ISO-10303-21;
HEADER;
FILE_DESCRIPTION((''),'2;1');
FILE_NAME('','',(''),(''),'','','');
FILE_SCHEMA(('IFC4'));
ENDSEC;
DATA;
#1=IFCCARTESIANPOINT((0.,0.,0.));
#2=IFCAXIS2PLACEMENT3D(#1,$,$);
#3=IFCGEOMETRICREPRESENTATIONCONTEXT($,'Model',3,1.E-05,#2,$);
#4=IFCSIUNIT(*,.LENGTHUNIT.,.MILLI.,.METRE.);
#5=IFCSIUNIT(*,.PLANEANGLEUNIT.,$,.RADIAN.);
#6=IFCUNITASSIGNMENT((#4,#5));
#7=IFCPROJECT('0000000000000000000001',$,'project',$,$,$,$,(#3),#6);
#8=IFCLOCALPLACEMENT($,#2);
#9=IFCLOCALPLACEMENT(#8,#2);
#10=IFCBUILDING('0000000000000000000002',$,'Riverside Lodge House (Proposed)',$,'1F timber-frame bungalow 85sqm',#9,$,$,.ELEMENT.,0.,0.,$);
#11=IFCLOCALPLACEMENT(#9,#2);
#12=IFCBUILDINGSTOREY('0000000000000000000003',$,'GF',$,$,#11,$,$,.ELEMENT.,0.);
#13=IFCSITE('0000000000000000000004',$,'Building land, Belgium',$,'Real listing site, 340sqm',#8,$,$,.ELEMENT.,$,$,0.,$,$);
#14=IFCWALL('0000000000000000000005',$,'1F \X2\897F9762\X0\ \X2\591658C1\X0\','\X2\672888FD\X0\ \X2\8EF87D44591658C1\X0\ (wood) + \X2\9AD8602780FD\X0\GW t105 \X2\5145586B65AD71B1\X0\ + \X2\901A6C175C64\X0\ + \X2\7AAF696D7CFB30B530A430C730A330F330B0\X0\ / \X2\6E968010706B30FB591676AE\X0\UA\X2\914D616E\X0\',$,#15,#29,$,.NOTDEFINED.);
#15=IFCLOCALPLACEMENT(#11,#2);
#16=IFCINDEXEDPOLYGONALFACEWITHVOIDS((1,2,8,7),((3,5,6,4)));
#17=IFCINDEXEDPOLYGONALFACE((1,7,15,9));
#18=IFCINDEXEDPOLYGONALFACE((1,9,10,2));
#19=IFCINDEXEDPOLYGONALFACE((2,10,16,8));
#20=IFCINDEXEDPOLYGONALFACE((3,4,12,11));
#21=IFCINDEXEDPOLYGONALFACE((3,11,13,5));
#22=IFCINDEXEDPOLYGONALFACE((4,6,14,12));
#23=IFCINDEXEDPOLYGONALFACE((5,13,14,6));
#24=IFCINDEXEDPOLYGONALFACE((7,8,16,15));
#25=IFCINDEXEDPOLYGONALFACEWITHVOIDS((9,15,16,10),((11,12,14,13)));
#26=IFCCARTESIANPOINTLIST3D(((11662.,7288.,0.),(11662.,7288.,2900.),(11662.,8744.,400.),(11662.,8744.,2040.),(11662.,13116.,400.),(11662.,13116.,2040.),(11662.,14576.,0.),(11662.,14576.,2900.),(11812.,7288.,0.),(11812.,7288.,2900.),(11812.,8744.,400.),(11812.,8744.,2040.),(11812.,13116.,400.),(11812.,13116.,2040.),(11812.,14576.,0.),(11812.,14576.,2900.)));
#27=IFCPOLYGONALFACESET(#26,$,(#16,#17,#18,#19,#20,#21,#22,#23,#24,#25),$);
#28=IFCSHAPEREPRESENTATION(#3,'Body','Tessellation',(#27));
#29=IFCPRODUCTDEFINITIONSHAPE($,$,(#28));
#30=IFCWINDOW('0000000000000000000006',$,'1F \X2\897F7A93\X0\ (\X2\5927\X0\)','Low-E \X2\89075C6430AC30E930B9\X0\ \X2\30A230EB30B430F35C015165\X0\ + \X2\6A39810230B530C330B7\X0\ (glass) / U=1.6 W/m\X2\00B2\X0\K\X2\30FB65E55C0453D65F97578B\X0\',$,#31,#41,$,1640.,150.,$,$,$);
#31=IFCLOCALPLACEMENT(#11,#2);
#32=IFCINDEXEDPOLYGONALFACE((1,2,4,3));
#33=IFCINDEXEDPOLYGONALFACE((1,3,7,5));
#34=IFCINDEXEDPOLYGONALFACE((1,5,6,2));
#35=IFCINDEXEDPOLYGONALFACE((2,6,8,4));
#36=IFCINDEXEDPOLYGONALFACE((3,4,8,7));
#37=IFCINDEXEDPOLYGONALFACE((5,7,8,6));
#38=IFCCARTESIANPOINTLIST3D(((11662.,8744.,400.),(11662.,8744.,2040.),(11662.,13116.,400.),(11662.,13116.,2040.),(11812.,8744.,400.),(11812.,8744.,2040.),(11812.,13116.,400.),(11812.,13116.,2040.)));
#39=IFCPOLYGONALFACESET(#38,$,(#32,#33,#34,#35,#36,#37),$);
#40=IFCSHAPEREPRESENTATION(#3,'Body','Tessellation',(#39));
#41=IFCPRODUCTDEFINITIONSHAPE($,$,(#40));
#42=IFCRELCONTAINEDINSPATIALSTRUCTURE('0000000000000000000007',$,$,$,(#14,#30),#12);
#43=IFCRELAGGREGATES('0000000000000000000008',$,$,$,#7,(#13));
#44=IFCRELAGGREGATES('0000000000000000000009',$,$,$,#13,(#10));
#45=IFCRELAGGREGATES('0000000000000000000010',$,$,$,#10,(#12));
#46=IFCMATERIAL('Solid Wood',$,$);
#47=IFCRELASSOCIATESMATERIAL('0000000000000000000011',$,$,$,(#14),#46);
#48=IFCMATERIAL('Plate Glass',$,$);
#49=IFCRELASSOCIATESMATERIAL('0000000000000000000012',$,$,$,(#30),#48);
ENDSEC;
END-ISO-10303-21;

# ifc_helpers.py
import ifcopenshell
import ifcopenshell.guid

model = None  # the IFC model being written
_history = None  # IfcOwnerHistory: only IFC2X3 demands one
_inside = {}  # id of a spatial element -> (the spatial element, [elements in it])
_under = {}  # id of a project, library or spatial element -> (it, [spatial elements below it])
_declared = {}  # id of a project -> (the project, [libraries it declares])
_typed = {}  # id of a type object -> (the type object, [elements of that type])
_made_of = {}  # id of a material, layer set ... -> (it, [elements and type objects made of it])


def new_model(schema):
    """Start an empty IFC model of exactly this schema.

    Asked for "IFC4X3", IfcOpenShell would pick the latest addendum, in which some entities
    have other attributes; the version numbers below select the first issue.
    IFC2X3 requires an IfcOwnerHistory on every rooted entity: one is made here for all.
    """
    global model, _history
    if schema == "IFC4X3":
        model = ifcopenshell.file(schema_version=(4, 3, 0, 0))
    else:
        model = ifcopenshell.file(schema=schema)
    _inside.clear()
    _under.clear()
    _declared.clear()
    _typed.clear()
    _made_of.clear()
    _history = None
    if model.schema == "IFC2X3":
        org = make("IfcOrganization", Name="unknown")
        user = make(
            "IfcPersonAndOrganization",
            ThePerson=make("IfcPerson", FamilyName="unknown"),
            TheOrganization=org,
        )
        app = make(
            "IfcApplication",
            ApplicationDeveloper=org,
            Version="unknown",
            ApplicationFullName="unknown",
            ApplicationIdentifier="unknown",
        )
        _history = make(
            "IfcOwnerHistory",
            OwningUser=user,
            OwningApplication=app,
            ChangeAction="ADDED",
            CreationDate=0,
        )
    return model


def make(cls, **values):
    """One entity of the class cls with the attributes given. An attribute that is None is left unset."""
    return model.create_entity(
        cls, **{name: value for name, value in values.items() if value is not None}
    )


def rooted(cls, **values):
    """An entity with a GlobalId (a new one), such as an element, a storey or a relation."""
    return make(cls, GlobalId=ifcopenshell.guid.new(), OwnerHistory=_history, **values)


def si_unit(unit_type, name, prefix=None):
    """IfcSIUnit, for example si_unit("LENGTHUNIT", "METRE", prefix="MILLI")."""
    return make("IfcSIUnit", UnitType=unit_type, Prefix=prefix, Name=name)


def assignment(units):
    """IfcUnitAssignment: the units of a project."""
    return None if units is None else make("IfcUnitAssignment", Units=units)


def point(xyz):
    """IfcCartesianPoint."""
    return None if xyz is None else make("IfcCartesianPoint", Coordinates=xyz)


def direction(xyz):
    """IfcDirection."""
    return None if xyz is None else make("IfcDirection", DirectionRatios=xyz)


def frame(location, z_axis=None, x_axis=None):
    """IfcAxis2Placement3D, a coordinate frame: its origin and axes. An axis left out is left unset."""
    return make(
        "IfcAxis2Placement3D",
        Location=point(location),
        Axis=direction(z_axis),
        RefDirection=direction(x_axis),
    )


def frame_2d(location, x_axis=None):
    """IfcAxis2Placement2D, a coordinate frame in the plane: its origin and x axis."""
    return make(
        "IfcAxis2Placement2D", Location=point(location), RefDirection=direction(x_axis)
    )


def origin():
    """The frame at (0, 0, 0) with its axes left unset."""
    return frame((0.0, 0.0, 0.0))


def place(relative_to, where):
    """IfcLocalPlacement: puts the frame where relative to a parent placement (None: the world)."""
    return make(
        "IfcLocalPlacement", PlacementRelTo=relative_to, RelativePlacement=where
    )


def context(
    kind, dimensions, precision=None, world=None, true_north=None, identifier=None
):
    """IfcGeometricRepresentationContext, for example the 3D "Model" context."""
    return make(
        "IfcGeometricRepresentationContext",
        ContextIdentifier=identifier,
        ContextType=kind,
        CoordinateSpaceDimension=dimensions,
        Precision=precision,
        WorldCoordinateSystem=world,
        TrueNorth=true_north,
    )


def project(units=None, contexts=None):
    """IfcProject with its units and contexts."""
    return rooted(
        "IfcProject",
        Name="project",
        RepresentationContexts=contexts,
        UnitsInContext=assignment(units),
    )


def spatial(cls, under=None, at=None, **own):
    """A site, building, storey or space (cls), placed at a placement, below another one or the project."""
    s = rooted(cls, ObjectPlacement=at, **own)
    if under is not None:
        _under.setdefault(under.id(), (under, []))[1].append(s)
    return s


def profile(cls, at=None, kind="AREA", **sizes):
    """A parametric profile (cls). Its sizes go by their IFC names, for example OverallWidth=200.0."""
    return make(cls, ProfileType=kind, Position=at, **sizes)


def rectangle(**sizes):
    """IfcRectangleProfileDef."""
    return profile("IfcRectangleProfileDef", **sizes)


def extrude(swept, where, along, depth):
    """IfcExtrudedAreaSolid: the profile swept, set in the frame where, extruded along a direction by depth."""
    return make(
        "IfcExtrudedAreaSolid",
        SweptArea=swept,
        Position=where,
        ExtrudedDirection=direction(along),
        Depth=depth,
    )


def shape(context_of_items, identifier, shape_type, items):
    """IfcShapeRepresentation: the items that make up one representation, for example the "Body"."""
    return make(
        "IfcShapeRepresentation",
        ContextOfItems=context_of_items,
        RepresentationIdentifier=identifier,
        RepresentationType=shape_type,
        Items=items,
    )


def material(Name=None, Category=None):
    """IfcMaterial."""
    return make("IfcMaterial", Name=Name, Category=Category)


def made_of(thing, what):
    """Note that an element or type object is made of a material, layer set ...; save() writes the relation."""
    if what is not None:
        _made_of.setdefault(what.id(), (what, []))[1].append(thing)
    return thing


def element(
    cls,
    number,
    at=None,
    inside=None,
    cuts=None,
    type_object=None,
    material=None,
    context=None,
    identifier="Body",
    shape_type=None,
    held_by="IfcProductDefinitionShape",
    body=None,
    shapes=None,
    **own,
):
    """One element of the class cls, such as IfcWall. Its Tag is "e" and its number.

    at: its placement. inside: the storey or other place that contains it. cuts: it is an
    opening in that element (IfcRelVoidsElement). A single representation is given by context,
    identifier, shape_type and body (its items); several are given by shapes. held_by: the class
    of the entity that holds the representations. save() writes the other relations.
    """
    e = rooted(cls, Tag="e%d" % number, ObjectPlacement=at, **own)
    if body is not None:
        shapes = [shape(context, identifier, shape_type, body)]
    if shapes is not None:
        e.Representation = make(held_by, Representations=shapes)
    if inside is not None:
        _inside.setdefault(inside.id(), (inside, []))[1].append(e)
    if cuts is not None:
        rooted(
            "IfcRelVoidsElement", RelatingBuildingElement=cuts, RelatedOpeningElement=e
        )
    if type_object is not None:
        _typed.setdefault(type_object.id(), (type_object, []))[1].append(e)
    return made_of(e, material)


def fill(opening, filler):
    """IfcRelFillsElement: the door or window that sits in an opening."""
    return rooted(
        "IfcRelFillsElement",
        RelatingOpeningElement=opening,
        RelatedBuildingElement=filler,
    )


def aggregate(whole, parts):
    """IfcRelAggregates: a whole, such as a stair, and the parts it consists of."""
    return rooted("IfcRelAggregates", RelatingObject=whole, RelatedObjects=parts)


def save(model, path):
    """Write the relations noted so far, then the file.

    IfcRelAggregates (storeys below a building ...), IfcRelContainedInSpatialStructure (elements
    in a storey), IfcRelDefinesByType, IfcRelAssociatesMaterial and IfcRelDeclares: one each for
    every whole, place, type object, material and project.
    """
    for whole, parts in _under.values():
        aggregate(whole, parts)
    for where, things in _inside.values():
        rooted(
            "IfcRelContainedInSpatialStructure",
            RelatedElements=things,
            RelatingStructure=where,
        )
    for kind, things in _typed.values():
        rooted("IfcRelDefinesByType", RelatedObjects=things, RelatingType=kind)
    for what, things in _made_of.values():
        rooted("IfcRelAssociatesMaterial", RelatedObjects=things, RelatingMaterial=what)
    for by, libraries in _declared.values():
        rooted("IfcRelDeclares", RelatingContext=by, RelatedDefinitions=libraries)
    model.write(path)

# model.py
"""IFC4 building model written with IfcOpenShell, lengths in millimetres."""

from ifc_helpers import new_model, si_unit, frame, frame_2d, origin, place, context, project, spatial, rectangle, extrude, material, element, fill, save


model = new_model("IFC4")

# Units and contexts
model_context = context("Model", 3, precision=1e-05, world=origin())
ifc_project = project(units=[si_unit("LENGTHUNIT", "METRE", prefix="MILLI"), si_unit("PLANEANGLEUNIT", "RADIAN")], contexts=[model_context])

# Site, building, storey
site_placement = place(None, origin())
site = spatial("IfcSite", under=ifc_project, at=site_placement, Name="Building land, Belgium", ObjectType="Real listing site, 340sqm", CompositionType="ELEMENT", RefElevation=0.0)
building_placement = place(site_placement, origin())
building = spatial("IfcBuilding", under=site, at=building_placement, Name="Riverside Lodge House (Proposed)", ObjectType="1F timber-frame bungalow 85sqm", CompositionType="ELEMENT", ElevationOfRefHeight=0.0, ElevationOfTerrain=0.0)
storey_placement = place(building_placement, origin())
storey = spatial("IfcBuildingStorey", under=building, at=storey_placement, Name="GF", CompositionType="ELEMENT", Elevation=0.0)

# Shared definitions
ifc_material_1 = material(Name="Solid Wood")

# Shared definitions
ifc_material_2 = material(Name="Plate Glass")

# Wall, opening, window
wall_1_placement = place(storey_placement, frame((5831.0, 3644.0, 0.0)))
wall_1 = element("IfcWall", 1, at=wall_1_placement, inside=storey, material=ifc_material_1, Name="1F 西面 外壁", Description="木製 軸組外壁 (wood) + 高性能GW t105 充填断熱 + 通気層 + 窯業系サイディング / 準耐火・外皮UA配慮", PredefinedType="NOTDEFINED", context=model_context, shape_type="SweptSolid", body=[
    extrude(rectangle(XDim=150.0, YDim=7288.0, at=frame_2d((75.0, 3644.0))), frame((5831.0, 3644.0, 0.0)), (0.0, 0.0, 1.0), 2900.0),
])
opening_1_placement = place(storey_placement, frame((5831.0, 4372.0, 200.0)))
opening_1 = element("IfcOpeningElement", 2, at=opening_1_placement, cuts=wall_1, PredefinedType="NOTDEFINED", context=model_context, shape_type="SweptSolid", body=[
    extrude(rectangle(XDim=150.0, YDim=4372.0, at=frame_2d((75.0, 2186.0))), frame((5831.0, 4372.0, 200.0)), (0.0, 0.0, 1.0), 1640.0),
])
window_1_placement = place(storey_placement, frame((5831.0, 4372.0, 200.0)))
window_1 = element("IfcWindow", 3, at=window_1_placement, inside=storey, material=ifc_material_2, Name="1F 西窓 (大)", Description="Low-E 複層ガラス アルゴン封入 + 樹脂サッシ (glass) / U=1.6 W/m²K・日射取得型", OverallHeight=1640.0, OverallWidth=150.0, context=model_context, shape_type="SweptSolid", body=[
    extrude(rectangle(XDim=150.0, YDim=4372.0, at=frame_2d((75.0, 2186.0))), frame((5831.0, 4372.0, 200.0)), (0.0, 0.0, 1.0), 1640.0),
])
fill(opening_1, window_1)

save(model, "model.ifc")
